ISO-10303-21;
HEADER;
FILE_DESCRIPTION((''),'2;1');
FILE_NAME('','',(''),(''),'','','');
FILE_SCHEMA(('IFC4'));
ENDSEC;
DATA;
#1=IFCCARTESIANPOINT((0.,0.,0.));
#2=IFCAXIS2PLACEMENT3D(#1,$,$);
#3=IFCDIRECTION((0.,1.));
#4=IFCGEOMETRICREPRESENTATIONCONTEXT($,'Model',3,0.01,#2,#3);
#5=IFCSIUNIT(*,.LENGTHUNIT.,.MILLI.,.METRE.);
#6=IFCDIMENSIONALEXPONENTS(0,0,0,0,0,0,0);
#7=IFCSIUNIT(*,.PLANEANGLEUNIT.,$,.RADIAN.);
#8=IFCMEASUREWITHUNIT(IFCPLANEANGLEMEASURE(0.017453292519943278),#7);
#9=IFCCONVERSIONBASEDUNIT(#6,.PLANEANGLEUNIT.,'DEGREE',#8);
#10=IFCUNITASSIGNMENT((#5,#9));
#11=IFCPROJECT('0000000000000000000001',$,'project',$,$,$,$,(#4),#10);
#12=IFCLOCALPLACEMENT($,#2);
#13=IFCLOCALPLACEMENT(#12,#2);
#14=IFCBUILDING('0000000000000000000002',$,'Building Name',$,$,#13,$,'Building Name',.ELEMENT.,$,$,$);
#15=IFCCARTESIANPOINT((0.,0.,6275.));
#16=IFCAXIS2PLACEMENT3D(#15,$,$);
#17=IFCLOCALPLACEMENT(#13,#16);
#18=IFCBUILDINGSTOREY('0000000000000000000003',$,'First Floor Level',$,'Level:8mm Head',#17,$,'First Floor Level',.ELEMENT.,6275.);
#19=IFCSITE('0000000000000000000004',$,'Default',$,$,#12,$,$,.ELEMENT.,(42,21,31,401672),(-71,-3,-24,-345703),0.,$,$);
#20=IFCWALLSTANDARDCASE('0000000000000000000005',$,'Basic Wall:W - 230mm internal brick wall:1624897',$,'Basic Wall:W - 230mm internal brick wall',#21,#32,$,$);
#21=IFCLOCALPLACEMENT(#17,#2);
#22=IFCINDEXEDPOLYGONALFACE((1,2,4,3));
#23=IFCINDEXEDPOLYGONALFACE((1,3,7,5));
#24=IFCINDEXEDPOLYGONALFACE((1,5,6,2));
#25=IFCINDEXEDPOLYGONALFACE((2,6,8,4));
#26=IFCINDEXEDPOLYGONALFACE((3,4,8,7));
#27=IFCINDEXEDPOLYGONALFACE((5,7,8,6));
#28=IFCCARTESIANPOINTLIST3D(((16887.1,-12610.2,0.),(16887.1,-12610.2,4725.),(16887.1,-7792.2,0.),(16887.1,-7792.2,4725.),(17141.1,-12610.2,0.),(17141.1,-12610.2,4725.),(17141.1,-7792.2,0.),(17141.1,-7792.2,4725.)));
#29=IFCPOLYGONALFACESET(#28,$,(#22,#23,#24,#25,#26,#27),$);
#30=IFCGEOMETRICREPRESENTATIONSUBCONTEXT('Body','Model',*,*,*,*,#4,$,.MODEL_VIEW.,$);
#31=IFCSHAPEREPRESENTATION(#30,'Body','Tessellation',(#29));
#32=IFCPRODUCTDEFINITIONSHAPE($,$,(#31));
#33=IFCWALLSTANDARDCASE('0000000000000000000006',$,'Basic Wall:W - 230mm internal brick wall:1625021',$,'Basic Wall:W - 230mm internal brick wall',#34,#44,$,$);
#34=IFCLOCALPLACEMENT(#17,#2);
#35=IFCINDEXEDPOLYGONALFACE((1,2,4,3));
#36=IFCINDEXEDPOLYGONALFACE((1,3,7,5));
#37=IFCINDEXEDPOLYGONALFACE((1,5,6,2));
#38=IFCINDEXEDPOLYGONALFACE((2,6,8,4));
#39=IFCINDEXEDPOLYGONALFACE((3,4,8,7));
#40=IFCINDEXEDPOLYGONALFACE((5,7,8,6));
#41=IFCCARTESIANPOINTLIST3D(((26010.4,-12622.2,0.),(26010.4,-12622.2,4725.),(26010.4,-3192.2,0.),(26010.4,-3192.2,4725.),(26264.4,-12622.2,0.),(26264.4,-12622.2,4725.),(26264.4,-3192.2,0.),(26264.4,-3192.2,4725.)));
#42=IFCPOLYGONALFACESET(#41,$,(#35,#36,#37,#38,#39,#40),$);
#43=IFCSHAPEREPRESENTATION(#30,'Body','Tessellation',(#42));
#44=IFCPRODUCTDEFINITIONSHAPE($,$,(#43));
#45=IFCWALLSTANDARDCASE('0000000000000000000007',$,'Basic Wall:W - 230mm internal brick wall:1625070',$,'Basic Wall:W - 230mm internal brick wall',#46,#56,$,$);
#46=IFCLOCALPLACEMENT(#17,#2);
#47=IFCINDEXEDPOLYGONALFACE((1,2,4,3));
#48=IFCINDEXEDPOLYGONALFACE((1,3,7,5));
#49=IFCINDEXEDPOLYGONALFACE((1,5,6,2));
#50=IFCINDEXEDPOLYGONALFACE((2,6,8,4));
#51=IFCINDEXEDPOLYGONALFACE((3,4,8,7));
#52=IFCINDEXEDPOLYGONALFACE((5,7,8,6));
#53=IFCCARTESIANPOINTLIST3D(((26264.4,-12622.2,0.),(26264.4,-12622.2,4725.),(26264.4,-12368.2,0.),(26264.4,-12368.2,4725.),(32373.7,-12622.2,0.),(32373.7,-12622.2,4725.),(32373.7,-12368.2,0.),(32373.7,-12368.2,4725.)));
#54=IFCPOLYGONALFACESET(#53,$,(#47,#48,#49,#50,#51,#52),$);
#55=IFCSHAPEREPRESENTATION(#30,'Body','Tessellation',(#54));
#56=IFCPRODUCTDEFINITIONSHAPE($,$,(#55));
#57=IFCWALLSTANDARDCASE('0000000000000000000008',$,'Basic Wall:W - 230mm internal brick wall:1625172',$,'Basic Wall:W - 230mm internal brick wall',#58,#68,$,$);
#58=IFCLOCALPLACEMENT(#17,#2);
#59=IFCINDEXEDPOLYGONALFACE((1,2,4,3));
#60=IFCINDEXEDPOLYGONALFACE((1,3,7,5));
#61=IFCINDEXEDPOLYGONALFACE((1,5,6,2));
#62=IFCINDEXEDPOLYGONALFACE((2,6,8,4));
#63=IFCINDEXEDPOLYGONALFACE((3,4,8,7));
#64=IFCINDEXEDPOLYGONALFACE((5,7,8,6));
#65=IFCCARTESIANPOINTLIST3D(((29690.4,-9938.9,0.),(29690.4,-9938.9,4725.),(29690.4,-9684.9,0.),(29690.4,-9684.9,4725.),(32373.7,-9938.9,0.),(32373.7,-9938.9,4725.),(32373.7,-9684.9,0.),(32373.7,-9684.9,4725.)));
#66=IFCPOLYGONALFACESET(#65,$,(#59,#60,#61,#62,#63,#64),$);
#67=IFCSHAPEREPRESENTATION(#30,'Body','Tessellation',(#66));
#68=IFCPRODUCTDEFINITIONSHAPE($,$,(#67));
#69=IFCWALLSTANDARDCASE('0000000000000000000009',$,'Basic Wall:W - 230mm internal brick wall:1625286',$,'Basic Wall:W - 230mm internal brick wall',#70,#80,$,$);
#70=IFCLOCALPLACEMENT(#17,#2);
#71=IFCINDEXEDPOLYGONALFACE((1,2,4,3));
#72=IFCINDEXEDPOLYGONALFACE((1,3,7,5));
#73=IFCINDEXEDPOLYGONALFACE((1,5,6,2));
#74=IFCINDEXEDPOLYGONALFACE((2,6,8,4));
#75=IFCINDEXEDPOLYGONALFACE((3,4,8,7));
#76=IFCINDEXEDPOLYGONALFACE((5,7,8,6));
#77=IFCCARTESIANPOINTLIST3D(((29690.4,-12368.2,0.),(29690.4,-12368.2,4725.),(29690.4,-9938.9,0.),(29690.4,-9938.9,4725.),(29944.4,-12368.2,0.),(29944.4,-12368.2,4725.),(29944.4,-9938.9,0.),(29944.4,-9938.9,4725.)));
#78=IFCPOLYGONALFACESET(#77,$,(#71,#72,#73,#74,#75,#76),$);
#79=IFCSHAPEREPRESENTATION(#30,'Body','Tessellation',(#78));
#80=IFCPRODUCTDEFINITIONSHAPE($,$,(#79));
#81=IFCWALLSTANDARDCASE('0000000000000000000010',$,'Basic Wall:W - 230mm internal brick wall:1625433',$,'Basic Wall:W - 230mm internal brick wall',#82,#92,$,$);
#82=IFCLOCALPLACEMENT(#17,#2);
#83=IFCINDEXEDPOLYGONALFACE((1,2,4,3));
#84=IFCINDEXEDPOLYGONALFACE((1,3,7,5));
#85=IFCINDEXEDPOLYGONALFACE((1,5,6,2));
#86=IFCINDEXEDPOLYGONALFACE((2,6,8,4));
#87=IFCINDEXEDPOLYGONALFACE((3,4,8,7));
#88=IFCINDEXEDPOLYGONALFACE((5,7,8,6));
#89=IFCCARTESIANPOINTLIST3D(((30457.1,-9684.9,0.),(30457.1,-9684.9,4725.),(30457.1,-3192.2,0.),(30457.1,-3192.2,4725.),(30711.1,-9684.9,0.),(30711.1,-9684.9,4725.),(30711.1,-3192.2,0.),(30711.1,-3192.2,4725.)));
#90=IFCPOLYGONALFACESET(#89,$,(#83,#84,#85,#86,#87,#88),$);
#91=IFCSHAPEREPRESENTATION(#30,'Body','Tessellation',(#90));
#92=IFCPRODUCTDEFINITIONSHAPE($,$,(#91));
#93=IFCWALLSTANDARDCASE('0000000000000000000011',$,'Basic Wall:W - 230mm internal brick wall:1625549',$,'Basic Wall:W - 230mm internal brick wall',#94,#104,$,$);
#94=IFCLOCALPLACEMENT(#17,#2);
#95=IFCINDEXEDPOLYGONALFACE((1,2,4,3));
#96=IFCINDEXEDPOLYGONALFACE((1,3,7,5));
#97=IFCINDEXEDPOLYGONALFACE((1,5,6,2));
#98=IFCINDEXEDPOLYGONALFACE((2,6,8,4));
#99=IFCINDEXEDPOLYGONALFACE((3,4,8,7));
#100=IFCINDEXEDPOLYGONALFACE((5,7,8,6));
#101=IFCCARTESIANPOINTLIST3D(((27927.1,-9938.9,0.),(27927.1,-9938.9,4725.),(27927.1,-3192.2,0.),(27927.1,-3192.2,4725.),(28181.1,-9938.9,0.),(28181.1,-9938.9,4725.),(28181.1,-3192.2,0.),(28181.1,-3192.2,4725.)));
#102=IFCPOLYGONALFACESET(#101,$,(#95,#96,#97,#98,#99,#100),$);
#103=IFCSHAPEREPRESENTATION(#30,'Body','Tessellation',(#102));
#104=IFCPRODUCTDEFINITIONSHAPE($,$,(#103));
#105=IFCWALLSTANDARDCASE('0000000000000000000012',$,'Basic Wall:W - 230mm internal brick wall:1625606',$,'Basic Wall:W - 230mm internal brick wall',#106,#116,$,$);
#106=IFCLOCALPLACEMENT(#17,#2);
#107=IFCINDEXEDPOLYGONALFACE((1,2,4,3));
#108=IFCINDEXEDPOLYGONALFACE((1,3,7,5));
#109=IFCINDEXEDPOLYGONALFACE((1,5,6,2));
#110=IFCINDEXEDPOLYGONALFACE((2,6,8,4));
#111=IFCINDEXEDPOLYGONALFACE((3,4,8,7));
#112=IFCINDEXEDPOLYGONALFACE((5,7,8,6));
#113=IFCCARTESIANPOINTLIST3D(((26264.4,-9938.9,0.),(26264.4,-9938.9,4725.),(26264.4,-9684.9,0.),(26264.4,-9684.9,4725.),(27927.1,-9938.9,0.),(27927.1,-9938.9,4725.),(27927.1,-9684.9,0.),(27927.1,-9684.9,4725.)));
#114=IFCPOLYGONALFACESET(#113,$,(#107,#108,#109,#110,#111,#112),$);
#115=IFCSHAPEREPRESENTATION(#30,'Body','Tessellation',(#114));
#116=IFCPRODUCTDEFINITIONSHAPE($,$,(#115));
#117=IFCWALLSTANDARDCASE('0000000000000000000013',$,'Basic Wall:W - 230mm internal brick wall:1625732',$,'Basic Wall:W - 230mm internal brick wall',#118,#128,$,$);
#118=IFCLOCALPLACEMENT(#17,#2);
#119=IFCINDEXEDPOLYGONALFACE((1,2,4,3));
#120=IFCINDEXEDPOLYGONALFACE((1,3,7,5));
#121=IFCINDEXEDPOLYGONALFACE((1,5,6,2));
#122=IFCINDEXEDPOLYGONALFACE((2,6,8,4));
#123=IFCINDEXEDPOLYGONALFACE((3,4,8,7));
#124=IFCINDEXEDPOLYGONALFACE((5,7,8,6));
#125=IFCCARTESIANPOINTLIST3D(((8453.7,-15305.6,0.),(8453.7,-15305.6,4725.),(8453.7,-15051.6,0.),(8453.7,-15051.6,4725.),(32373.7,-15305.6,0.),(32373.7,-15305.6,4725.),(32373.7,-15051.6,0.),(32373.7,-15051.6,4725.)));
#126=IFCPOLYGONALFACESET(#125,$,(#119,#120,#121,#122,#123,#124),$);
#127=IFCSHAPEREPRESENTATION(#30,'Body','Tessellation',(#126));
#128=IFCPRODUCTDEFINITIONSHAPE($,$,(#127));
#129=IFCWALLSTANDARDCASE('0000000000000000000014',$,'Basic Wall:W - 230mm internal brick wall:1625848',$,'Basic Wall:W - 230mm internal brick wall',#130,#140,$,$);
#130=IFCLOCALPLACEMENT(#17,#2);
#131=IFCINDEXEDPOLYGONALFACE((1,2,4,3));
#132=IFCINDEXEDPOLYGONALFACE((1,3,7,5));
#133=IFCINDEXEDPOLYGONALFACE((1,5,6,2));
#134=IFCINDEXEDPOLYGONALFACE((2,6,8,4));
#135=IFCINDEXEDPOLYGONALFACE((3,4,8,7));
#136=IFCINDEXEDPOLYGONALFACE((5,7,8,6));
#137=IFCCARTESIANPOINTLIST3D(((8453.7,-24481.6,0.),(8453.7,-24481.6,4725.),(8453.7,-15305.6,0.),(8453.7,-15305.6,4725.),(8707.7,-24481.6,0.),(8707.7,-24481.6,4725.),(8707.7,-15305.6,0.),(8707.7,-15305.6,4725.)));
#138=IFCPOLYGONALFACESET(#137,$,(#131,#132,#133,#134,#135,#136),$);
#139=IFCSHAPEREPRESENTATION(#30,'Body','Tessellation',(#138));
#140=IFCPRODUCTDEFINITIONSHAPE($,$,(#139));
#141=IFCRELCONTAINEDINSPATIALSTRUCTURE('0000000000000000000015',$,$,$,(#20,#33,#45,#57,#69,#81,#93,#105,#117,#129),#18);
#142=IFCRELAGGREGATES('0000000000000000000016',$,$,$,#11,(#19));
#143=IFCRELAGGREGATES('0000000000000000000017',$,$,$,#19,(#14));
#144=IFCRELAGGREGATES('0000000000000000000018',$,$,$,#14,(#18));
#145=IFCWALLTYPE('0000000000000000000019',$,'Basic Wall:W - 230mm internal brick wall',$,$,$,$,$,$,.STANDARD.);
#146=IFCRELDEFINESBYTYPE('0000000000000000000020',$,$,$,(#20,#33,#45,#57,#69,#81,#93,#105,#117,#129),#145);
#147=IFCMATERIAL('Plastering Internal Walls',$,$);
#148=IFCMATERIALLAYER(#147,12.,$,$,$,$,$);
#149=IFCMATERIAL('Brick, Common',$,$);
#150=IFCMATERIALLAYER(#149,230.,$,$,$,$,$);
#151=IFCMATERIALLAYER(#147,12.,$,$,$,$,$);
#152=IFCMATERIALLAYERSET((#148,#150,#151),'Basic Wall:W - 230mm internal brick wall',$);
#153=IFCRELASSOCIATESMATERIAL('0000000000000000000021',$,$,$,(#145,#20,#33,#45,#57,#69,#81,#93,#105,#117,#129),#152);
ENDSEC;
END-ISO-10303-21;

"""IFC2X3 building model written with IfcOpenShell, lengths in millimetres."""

from ifc_helpers import new_model, entity, si_unit, converted_unit, direction, frame, frame_2d, origin, place, context, subcontext, project, spatial, rectangle, extrude, material, layer, layer_set, layer_usage, type_object, element, save


model = new_model("IFC2X3")

# Units and contexts
model_context = context("Model", 3, precision=0.01, world=origin(), true_north=direction((0.0, 1.0)))
body_context = subcontext(model_context, "Body", "Model", "MODEL_VIEW")
ifc_project = project(units=[si_unit("LENGTHUNIT", "METRE", prefix="MILLI"), converted_unit("PLANEANGLEUNIT", "DEGREE", entity("IfcPlaneAngleMeasure", 0.017453292519943278), si_unit("PLANEANGLEUNIT", "RADIAN"), dimensions=[0, 0, 0, 0, 0, 0, 0])], contexts=[model_context])

# Site, building, storey
site_placement = place(None, origin())
site = spatial("IfcSite", under=ifc_project, at=site_placement, Name="Default", CompositionType="ELEMENT", RefLatitude=(42, 21, 31, 401672), RefLongitude=(-71, -3, -24, -345703), RefElevation=0.0)
building_placement = place(site_placement, origin())
building = spatial("IfcBuilding", under=site, at=building_placement, Name="Building Name", LongName="Building Name", CompositionType="ELEMENT")
storey_placement = place(building_placement, frame((0.0, 0.0, 6275.0)))
storey = spatial("IfcBuildingStorey", under=building, at=storey_placement, Name="First Floor Level", ObjectType="Level:8mm Head", LongName="First Floor Level", CompositionType="ELEMENT", Elevation=6275.0)

# Walls
ifc_material_1 = material(Name="Brick, Common")
ifc_material_2 = material(Name="Plastering Internal Walls")
ifc_layer_1 = layer(ifc_material_2, 12.0)
ifc_layer_2 = layer(ifc_material_1, 230.0)
ifc_layer_3 = layer(ifc_material_2, 12.0)
ifc_layer_set_1 = layer_set([ifc_layer_1, ifc_layer_2, ifc_layer_3], Name="Basic Wall:W - 230mm internal brick wall")
wall_type_1 = type_object("IfcWallType", Name="Basic Wall:W - 230mm internal brick wall", PredefinedType="STANDARD", material=ifc_layer_set_1)
ifc_layer_usage_1 = layer_usage(ifc_layer_set_1, "AXIS2", "NEGATIVE", 127.0)
wall_1_placement = place(storey_placement, frame((17014.1, -7792.2, 0.0), z_axis=(0.0, 0.0, 1.0), x_axis=(0.0, -1.0, 0.0)))
element("IfcWallStandardCase", 1, at=wall_1_placement, inside=storey, type_object=wall_type_1, material=ifc_layer_usage_1, Name="Basic Wall:W - 230mm internal brick wall:1624897", ObjectType="Basic Wall:W - 230mm internal brick wall", context=body_context, shape_type="SweptSolid", body=[
    extrude(rectangle(XDim=4818.0, YDim=254.0, at=frame_2d((2409.0, 0.0), x_axis=(-1.0, 0.0))), origin(), (0.0, 0.0, 1.0), 4725.0),
])
ifc_layer_usage_2 = layer_usage(ifc_layer_set_1, "AXIS2", "NEGATIVE", 127.0)
wall_2_placement = place(storey_placement, frame((26137.4, -3192.2, 0.0), z_axis=(0.0, 0.0, 1.0), x_axis=(0.0, -1.0, 0.0)))
element("IfcWallStandardCase", 2, at=wall_2_placement, inside=storey, type_object=wall_type_1, material=ifc_layer_usage_2, Name="Basic Wall:W - 230mm internal brick wall:1625021", ObjectType="Basic Wall:W - 230mm internal brick wall", context=body_context, shape_type="SweptSolid", body=[
    extrude(rectangle(XDim=9430.0, YDim=254.0, at=frame_2d((4715.0, 0.0), x_axis=(-1.0, 0.0))), origin(), (0.0, 0.0, 1.0), 4725.0),
])
ifc_layer_usage_3 = layer_usage(ifc_layer_set_1, "AXIS2", "NEGATIVE", 127.0)
wall_3_placement = place(storey_placement, frame((26264.4, -12495.2, 0.0)))
element("IfcWallStandardCase", 3, at=wall_3_placement, inside=storey, type_object=wall_type_1, material=ifc_layer_usage_3, Name="Basic Wall:W - 230mm internal brick wall:1625070", ObjectType="Basic Wall:W - 230mm internal brick wall", context=body_context, shape_type="SweptSolid", body=[
    extrude(rectangle(XDim=6109.3, YDim=254.0, at=frame_2d((3054.7, 0.0), x_axis=(-1.0, 0.0))), origin(), (0.0, 0.0, 1.0), 4725.0),
])
ifc_layer_usage_4 = layer_usage(ifc_layer_set_1, "AXIS2", "NEGATIVE", 127.0)
wall_4_placement = place(storey_placement, frame((32373.7, -9811.9, 0.0), z_axis=(0.0, 0.0, 1.0), x_axis=(-1.0, 0.0, 0.0)))
element("IfcWallStandardCase", 4, at=wall_4_placement, inside=storey, type_object=wall_type_1, material=ifc_layer_usage_4, Name="Basic Wall:W - 230mm internal brick wall:1625172", ObjectType="Basic Wall:W - 230mm internal brick wall", context=body_context, shape_type="SweptSolid", body=[
    extrude(rectangle(XDim=2683.3, YDim=254.0, at=frame_2d((1341.7, 0.0), x_axis=(-1.0, 0.0))), origin(), (0.0, 0.0, 1.0), 4725.0),
])
ifc_layer_usage_5 = layer_usage(ifc_layer_set_1, "AXIS2", "NEGATIVE", 127.0)
wall_5_placement = place(storey_placement, frame((29817.4, -9938.9, 0.0), z_axis=(0.0, 0.0, 1.0), x_axis=(0.0, -1.0, 0.0)))
element("IfcWallStandardCase", 5, at=wall_5_placement, inside=storey, type_object=wall_type_1, material=ifc_layer_usage_5, Name="Basic Wall:W - 230mm internal brick wall:1625286", ObjectType="Basic Wall:W - 230mm internal brick wall", context=body_context, shape_type="SweptSolid", body=[
    extrude(rectangle(XDim=2429.3, YDim=254.0, at=frame_2d((1214.7, 0.0), x_axis=(-1.0, 0.0))), origin(), (0.0, 0.0, 1.0), 4725.0),
])
ifc_layer_usage_6 = layer_usage(ifc_layer_set_1, "AXIS2", "NEGATIVE", 127.0)
wall_6_placement = place(storey_placement, frame((30584.1, -3192.2, 0.0), z_axis=(0.0, 0.0, 1.0), x_axis=(0.0, -1.0, 0.0)))
element("IfcWallStandardCase", 6, at=wall_6_placement, inside=storey, type_object=wall_type_1, material=ifc_layer_usage_6, Name="Basic Wall:W - 230mm internal brick wall:1625433", ObjectType="Basic Wall:W - 230mm internal brick wall", context=body_context, shape_type="SweptSolid", body=[
    extrude(rectangle(XDim=6492.7, YDim=254.0, at=frame_2d((3246.3, 0.0), x_axis=(-1.0, 0.0))), origin(), (0.0, 0.0, 1.0), 4725.0),
])
ifc_layer_usage_7 = layer_usage(ifc_layer_set_1, "AXIS2", "NEGATIVE", 127.0)
wall_7_placement = place(storey_placement, frame((28054.1, -3192.2, 0.0), z_axis=(0.0, 0.0, 1.0), x_axis=(0.0, -1.0, 0.0)))
element("IfcWallStandardCase", 7, at=wall_7_placement, inside=storey, type_object=wall_type_1, material=ifc_layer_usage_7, Name="Basic Wall:W - 230mm internal brick wall:1625549", ObjectType="Basic Wall:W - 230mm internal brick wall", context=body_context, shape_type="SweptSolid", body=[
    extrude(rectangle(XDim=6746.7, YDim=254.0, at=frame_2d((3373.3, 0.0), x_axis=(-1.0, 0.0))), origin(), (0.0, 0.0, 1.0), 4725.0),
])
ifc_layer_usage_8 = layer_usage(ifc_layer_set_1, "AXIS2", "NEGATIVE", 127.0)
wall_8_placement = place(storey_placement, frame((27927.1, -9811.9, 0.0), z_axis=(0.0, 0.0, 1.0), x_axis=(-1.0, 0.0, 0.0)))
element("IfcWallStandardCase", 8, at=wall_8_placement, inside=storey, type_object=wall_type_1, material=ifc_layer_usage_8, Name="Basic Wall:W - 230mm internal brick wall:1625606", ObjectType="Basic Wall:W - 230mm internal brick wall", context=body_context, shape_type="SweptSolid", body=[
    extrude(rectangle(XDim=1662.7, YDim=254.0, at=frame_2d((831.3, 0.0), x_axis=(-1.0, 0.0))), origin(), (0.0, 0.0, 1.0), 4725.0),
])
ifc_layer_usage_9 = layer_usage(ifc_layer_set_1, "AXIS2", "NEGATIVE", 127.0)
wall_9_placement = place(storey_placement, frame((32373.7, -15178.6, 0.0), z_axis=(0.0, 0.0, 1.0), x_axis=(-1.0, 0.0, 0.0)))
element("IfcWallStandardCase", 9, at=wall_9_placement, inside=storey, type_object=wall_type_1, material=ifc_layer_usage_9, Name="Basic Wall:W - 230mm internal brick wall:1625732", ObjectType="Basic Wall:W - 230mm internal brick wall", context=body_context, shape_type="SweptSolid", body=[
    extrude(rectangle(XDim=23920.0, YDim=254.0, at=frame_2d((11960.0, 0.0), x_axis=(-1.0, 0.0))), origin(), (0.0, 0.0, 1.0), 4725.0),
])
ifc_layer_usage_10 = layer_usage(ifc_layer_set_1, "AXIS2", "NEGATIVE", 127.0)
wall_10_placement = place(storey_placement, frame((8580.7, -15305.6, 0.0), z_axis=(0.0, 0.0, 1.0), x_axis=(0.0, -1.0, 0.0)))
element("IfcWallStandardCase", 10, at=wall_10_placement, inside=storey, type_object=wall_type_1, material=ifc_layer_usage_10, Name="Basic Wall:W - 230mm internal brick wall:1625848", ObjectType="Basic Wall:W - 230mm internal brick wall", context=body_context, shape_type="SweptSolid", body=[
    extrude(rectangle(XDim=9176.0, YDim=254.0, at=frame_2d((4588.0, 0.0), x_axis=(-1.0, 0.0))), origin(), (0.0, 0.0, 1.0), 4725.0),
])

save(model, "model.ifc")
